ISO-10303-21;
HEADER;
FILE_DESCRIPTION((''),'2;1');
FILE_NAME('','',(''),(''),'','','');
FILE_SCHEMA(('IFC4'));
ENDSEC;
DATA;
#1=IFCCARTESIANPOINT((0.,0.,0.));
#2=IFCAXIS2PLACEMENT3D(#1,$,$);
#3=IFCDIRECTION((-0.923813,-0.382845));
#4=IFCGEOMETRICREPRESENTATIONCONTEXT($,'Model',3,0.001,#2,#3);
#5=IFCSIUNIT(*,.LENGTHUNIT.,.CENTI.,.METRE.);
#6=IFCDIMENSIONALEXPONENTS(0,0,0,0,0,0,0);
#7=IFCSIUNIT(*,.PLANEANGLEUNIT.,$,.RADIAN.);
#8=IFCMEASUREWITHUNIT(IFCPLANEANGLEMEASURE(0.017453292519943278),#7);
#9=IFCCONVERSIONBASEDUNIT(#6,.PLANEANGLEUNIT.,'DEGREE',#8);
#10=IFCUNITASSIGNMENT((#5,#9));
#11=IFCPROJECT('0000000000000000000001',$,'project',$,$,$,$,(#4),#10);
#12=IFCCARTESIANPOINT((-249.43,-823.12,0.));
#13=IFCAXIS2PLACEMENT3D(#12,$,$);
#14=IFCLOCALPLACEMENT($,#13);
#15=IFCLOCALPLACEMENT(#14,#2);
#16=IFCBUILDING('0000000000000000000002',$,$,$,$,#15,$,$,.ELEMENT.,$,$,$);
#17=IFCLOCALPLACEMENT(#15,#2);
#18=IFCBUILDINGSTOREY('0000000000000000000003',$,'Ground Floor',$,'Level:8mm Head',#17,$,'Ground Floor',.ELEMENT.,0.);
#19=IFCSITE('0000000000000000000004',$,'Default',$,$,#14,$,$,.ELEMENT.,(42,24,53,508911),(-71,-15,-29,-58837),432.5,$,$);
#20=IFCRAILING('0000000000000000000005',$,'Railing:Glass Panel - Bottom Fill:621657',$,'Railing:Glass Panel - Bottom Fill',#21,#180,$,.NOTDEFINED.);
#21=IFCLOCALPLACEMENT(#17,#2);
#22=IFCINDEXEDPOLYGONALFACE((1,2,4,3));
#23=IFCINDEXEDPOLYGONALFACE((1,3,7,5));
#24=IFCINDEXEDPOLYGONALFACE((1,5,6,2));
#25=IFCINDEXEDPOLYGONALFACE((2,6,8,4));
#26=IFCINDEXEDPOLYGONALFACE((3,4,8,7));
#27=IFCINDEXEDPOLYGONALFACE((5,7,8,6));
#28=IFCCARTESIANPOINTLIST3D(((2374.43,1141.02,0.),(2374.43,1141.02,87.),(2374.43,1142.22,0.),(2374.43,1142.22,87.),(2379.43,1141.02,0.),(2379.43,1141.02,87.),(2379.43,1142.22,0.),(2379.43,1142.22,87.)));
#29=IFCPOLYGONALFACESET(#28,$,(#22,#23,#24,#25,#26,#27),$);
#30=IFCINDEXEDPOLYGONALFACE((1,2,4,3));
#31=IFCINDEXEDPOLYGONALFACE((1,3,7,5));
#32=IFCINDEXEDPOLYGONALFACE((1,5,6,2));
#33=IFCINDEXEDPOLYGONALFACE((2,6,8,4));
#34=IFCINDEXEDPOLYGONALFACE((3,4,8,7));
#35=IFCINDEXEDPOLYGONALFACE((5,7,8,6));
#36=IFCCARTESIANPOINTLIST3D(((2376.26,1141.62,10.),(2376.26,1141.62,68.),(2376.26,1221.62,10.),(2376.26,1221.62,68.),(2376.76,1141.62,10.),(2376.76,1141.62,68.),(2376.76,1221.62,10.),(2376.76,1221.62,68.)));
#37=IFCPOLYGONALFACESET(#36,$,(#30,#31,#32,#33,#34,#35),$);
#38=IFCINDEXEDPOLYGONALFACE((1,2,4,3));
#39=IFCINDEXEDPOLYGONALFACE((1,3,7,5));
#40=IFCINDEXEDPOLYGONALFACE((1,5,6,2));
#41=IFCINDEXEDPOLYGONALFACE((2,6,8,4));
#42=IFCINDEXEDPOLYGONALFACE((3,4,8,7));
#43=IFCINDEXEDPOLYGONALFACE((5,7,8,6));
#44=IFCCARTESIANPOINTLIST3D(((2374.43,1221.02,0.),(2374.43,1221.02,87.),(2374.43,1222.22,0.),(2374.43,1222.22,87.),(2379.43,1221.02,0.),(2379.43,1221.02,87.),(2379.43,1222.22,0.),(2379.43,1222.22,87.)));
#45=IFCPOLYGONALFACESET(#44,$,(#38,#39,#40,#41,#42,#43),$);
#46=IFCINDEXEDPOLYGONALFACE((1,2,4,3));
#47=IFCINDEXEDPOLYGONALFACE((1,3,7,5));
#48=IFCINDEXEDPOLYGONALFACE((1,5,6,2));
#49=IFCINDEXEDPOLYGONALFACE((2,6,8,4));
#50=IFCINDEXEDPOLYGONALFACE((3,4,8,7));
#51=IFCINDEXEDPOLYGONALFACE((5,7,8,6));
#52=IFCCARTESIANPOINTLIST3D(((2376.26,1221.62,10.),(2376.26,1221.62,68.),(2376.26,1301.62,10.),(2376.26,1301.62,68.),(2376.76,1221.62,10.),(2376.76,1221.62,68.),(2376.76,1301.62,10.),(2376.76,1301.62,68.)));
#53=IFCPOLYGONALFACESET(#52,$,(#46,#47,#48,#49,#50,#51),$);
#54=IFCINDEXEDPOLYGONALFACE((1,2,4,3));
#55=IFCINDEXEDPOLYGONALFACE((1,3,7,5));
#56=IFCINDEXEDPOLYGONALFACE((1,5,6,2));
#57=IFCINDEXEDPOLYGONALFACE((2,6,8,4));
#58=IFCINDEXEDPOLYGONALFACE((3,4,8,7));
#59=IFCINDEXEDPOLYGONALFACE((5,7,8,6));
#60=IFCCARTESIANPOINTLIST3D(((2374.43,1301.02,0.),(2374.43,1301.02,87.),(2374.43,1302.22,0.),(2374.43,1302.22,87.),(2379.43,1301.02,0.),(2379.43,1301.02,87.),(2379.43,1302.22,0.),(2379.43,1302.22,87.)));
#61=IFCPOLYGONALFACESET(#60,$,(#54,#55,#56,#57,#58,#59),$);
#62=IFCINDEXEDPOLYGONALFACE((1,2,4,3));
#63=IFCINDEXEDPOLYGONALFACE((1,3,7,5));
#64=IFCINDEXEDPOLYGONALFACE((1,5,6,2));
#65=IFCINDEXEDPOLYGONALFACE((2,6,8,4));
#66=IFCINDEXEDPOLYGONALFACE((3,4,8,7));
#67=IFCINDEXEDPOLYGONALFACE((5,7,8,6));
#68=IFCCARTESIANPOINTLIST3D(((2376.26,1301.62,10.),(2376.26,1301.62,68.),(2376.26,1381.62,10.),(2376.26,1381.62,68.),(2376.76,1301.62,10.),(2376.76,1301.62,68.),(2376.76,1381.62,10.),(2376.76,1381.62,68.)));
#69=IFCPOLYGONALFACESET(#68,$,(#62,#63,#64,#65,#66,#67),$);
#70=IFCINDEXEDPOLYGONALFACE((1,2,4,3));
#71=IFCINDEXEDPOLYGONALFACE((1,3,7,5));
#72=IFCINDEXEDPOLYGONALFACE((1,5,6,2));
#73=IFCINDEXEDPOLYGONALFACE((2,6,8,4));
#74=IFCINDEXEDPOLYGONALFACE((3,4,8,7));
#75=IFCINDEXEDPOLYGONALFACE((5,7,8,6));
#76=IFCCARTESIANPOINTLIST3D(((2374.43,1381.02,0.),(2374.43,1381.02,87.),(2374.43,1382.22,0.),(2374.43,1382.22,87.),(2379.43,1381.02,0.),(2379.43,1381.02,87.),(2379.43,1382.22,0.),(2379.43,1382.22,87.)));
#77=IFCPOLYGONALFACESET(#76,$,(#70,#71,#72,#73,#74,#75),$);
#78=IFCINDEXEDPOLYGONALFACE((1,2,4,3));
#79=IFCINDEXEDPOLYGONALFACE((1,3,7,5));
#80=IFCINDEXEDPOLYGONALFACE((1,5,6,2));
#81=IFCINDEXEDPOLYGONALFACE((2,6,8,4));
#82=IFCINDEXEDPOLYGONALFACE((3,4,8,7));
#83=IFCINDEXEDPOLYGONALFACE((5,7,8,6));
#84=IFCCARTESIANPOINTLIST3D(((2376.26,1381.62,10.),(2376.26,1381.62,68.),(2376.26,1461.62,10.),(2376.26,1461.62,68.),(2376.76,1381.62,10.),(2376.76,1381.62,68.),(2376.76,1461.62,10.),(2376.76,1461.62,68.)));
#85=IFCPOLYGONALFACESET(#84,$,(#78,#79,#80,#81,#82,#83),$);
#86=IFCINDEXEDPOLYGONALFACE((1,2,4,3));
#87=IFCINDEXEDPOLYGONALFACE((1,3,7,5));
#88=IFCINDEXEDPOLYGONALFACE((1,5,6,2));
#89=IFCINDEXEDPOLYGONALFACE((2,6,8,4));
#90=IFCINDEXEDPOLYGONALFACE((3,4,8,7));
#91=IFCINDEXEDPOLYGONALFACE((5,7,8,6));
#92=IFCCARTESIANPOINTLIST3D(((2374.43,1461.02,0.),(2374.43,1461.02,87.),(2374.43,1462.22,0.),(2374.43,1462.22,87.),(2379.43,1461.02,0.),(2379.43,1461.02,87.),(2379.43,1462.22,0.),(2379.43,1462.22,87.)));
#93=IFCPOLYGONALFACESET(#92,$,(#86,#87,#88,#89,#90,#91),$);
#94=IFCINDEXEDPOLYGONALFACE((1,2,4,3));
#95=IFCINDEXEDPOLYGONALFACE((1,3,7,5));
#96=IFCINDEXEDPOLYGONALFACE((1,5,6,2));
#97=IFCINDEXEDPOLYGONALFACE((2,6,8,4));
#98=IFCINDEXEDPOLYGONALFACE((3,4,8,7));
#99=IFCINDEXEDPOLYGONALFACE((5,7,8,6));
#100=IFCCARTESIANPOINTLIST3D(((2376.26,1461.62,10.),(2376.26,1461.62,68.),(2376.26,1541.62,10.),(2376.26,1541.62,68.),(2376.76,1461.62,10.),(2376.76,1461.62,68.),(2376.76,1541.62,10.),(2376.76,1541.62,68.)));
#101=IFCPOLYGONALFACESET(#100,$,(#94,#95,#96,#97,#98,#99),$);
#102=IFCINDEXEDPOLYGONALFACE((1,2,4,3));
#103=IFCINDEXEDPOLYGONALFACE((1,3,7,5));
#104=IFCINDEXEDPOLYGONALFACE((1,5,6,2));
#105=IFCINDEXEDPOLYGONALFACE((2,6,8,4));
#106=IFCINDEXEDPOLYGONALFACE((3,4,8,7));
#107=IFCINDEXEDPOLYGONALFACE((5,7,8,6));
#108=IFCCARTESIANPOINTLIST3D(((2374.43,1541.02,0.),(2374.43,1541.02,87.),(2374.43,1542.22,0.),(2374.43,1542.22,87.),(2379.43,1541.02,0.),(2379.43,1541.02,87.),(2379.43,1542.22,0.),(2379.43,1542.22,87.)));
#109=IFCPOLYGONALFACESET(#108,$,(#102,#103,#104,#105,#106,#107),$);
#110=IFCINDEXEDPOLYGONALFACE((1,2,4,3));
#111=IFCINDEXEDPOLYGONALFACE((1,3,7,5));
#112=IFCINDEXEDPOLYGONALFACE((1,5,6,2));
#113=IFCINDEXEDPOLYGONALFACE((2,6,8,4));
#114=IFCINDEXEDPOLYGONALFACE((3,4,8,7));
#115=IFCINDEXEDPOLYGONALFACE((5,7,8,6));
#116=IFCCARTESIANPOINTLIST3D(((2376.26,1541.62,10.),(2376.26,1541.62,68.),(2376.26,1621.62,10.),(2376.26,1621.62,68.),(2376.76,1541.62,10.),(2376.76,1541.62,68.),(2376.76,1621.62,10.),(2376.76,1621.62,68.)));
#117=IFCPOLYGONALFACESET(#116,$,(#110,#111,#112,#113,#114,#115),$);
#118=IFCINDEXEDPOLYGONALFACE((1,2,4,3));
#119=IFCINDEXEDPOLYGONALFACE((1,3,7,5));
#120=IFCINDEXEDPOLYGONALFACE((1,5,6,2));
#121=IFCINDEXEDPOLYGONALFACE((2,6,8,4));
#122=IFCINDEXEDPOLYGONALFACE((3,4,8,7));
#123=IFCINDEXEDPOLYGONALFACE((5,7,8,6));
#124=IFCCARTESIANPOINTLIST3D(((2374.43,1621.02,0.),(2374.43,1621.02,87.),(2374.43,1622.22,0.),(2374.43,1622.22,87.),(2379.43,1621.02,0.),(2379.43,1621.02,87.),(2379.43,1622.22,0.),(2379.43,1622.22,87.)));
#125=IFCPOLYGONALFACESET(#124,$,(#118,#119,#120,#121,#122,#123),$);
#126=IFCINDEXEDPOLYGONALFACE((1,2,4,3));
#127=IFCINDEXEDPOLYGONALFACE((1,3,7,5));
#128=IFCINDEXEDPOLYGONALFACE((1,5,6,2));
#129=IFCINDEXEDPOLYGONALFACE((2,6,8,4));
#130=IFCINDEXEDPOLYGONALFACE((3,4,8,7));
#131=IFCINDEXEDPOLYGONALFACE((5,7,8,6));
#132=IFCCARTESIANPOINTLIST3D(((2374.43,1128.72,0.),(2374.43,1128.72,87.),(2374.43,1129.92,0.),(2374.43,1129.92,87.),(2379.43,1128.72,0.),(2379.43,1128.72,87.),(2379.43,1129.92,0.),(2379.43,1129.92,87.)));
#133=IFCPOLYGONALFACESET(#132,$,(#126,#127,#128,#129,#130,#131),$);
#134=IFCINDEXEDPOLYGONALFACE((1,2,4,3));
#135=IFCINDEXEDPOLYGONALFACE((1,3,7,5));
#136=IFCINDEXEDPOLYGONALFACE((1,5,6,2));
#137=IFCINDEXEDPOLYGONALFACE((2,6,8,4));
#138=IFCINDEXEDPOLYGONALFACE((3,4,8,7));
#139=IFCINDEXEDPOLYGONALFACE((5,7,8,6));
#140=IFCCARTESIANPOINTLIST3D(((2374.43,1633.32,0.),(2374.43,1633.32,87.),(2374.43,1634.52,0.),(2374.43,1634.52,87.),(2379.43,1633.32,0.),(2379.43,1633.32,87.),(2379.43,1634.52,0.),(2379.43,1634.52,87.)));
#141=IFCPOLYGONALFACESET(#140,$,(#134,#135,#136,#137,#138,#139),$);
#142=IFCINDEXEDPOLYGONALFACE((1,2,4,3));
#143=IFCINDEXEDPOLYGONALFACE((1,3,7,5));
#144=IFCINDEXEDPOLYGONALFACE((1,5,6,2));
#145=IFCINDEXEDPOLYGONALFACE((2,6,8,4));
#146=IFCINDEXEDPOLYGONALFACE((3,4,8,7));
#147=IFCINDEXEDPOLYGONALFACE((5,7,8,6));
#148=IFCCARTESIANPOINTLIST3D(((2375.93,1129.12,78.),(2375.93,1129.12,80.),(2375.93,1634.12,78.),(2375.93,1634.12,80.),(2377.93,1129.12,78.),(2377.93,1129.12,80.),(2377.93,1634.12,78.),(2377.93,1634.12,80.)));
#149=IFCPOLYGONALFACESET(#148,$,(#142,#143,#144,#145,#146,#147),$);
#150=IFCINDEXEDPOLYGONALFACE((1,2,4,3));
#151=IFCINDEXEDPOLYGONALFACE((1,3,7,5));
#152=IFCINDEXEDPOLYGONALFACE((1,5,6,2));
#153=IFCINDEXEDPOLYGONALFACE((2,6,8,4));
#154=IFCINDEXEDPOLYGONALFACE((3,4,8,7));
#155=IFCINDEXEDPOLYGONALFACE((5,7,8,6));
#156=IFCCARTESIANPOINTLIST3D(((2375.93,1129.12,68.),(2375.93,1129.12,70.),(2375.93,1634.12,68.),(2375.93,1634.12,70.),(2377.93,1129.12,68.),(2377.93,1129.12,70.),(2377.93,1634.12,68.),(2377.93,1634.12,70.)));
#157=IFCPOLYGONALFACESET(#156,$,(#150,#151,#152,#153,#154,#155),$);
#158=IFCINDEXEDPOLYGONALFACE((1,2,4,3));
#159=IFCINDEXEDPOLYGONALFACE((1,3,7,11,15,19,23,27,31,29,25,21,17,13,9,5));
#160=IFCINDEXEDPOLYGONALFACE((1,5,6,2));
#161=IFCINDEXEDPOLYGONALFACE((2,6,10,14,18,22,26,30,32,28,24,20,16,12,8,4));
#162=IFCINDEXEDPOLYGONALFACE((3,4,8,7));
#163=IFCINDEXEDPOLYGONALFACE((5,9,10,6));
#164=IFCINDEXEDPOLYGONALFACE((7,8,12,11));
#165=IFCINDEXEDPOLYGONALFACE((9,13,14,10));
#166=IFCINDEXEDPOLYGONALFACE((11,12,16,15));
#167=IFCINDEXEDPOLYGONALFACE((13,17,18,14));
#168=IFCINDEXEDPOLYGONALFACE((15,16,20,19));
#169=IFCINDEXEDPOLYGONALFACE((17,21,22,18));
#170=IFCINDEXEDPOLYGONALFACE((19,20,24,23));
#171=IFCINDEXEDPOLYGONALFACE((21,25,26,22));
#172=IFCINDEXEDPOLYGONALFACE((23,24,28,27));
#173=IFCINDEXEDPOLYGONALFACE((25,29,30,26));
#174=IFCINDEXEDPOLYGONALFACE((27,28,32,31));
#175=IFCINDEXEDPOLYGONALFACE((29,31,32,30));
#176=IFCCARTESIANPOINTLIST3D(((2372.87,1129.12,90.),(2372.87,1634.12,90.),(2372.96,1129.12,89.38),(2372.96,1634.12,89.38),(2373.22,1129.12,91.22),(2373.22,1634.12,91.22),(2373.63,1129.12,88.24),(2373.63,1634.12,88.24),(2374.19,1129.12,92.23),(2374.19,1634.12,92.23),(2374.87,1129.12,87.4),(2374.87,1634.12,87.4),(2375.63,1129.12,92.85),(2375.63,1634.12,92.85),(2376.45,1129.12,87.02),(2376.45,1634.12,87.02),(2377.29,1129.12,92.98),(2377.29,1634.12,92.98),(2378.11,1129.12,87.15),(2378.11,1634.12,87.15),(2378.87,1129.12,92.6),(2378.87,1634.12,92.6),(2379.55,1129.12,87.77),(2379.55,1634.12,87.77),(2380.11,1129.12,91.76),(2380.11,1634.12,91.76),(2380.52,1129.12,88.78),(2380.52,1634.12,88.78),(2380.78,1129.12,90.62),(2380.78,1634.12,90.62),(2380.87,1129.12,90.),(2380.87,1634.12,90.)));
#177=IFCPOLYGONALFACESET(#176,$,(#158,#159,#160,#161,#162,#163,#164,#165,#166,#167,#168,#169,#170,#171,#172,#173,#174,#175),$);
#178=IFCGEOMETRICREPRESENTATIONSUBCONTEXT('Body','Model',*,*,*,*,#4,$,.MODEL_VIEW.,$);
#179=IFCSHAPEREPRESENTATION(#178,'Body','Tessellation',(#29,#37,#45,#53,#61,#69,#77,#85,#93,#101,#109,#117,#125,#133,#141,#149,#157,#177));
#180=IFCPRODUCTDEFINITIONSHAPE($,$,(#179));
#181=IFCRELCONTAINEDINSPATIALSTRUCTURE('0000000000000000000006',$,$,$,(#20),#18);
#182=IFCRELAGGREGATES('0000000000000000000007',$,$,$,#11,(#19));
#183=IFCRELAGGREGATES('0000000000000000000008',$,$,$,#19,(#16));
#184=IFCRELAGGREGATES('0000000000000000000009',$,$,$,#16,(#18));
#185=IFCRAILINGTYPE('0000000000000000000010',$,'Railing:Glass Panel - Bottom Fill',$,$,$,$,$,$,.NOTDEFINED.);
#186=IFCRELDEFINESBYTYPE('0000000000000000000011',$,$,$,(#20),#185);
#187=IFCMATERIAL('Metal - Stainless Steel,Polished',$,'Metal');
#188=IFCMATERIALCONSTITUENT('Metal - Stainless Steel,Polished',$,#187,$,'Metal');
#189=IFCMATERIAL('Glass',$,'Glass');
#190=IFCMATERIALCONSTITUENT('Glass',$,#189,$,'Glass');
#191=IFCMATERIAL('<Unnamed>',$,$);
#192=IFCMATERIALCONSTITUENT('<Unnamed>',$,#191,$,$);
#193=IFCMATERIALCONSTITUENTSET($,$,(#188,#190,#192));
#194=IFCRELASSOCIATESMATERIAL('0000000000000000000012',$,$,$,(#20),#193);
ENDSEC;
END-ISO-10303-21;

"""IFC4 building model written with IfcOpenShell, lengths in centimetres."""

from ifc_helpers import new_model, entity, si_unit, converted_unit, direction, frame, origin, place, context, subcontext, project, spatial, indexed_curve, outline, extrude, material, constituent, constituent_set, type_object, element, save


model = new_model("IFC4")

# Units and contexts
model_context = context("Model", 3, precision=0.001, world=origin(), true_north=direction((-0.923813, -0.382845)))
body_context = subcontext(model_context, "Body", "Model", "MODEL_VIEW")
ifc_project = project(units=[si_unit("LENGTHUNIT", "METRE", prefix="CENTI"), converted_unit("PLANEANGLEUNIT", "DEGREE", entity("IfcPlaneAngleMeasure", 0.017453292519943278), si_unit("PLANEANGLEUNIT", "RADIAN"), dimensions=[0, 0, 0, 0, 0, 0, 0])], contexts=[model_context])

# Site, building, storey
site_placement = place(None, frame((-249.43, -823.12, 0.0)))
site = spatial("IfcSite", under=ifc_project, at=site_placement, Name="Default", CompositionType="ELEMENT", RefLatitude=(42, 24, 53, 508911), RefLongitude=(-71, -15, -29, -58837), RefElevation=432.5)
building_placement = place(site_placement, origin())
building = spatial("IfcBuilding", under=site, at=building_placement, CompositionType="ELEMENT")
storey_placement = place(building_placement, origin())
storey = spatial("IfcBuildingStorey", under=building, at=storey_placement, Name="Ground Floor", ObjectType="Level:8mm Head", LongName="Ground Floor", CompositionType="ELEMENT", Elevation=0.0)

# Shared definitions
ifc_material_1 = material(Name="Glass", Category="Glass")

# Railing
ifc_material_2 = material(Name="Metal - Stainless Steel,Polished", Category="Metal")
ifc_material_3 = material(Name="<Unnamed>")
railing_type = type_object("IfcRailingType", Name="Railing:Glass Panel - Bottom Fill", PredefinedType="NOTDEFINED")
ifc_constituent_1 = constituent(ifc_material_2, Name="Metal - Stainless Steel,Polished", Category="Metal")
ifc_constituent_2 = constituent(ifc_material_1, Name="Glass", Category="Glass")
ifc_constituent_3 = constituent(ifc_material_3, Name="<Unnamed>")
ifc_constituent_set_1 = constituent_set(constituents=[ifc_constituent_1, ifc_constituent_2, ifc_constituent_3])
railing_1_placement = place(storey_placement, origin())
element("IfcRailing", 1, at=railing_1_placement, inside=storey, type_object=railing_type, material=ifc_constituent_set_1, Name="Railing:Glass Panel - Bottom Fill:621657", ObjectType="Railing:Glass Panel - Bottom Fill", PredefinedType="NOTDEFINED", context=body_context, shape_type="SweptSolid", body=[
    extrude(outline(indexed_curve([(-2.5, -0.6), (2.5, -0.6), (2.5, 0.6), (-2.5, 0.6), (-2.5, -0.6)], self_intersect=False)), frame((2376.93, 1141.62, 0.0), z_axis=(0.0, 0.0, 1.0), x_axis=(-1.0, 0.0, 0.0)), (0.0, 0.0, 1.0), 87.0),
    extrude(outline(indexed_curve([(-0.25, -40.0), (0.25, -40.0), (0.25, 40.0), (-0.25, 40.0), (-0.25, -40.0)], self_intersect=False)), frame((2376.51, 1181.62, 10.0), z_axis=(0.0, 0.0, 1.0), x_axis=(-1.0, 0.0, 0.0)), (0.0, 0.0, 1.0), 58.0),
    extrude(outline(indexed_curve([(-2.5, -0.6), (2.5, -0.6), (2.5, 0.6), (-2.5, 0.6), (-2.5, -0.6)], self_intersect=False)), frame((2376.93, 1221.62, 0.0), z_axis=(0.0, 0.0, 1.0), x_axis=(-1.0, 0.0, 0.0)), (0.0, 0.0, 1.0), 87.0),
    extrude(outline(indexed_curve([(-0.25, -40.0), (0.25, -40.0), (0.25, 40.0), (-0.25, 40.0), (-0.25, -40.0)], self_intersect=False)), frame((2376.51, 1261.62, 10.0), z_axis=(0.0, 0.0, 1.0), x_axis=(-1.0, 0.0, 0.0)), (0.0, 0.0, 1.0), 58.0),
    extrude(outline(indexed_curve([(-2.5, -0.6), (2.5, -0.6), (2.5, 0.6), (-2.5, 0.6), (-2.5, -0.6)], self_intersect=False)), frame((2376.93, 1301.62, 0.0), z_axis=(0.0, 0.0, 1.0), x_axis=(-1.0, 0.0, 0.0)), (0.0, 0.0, 1.0), 87.0),
    extrude(outline(indexed_curve([(-0.25, -40.0), (0.25, -40.0), (0.25, 40.0), (-0.25, 40.0), (-0.25, -40.0)], self_intersect=False)), frame((2376.51, 1341.62, 10.0), z_axis=(0.0, 0.0, 1.0), x_axis=(-1.0, 0.0, 0.0)), (0.0, 0.0, 1.0), 58.0),
    extrude(outline(indexed_curve([(-2.5, -0.6), (2.5, -0.6), (2.5, 0.6), (-2.5, 0.6), (-2.5, -0.6)], self_intersect=False)), frame((2376.93, 1381.62, 0.0), z_axis=(0.0, 0.0, 1.0), x_axis=(-1.0, 0.0, 0.0)), (0.0, 0.0, 1.0), 87.0),
    extrude(outline(indexed_curve([(-0.25, -40.0), (0.25, -40.0), (0.25, 40.0), (-0.25, 40.0), (-0.25, -40.0)], self_intersect=False)), frame((2376.51, 1421.62, 10.0), z_axis=(0.0, 0.0, 1.0), x_axis=(-1.0, 0.0, 0.0)), (0.0, 0.0, 1.0), 58.0),
    extrude(outline(indexed_curve([(-2.5, -0.6), (2.5, -0.6), (2.5, 0.6), (-2.5, 0.6), (-2.5, -0.6)], self_intersect=False)), frame((2376.93, 1461.62, 0.0), z_axis=(0.0, 0.0, 1.0), x_axis=(-1.0, 0.0, 0.0)), (0.0, 0.0, 1.0), 87.0),
    extrude(outline(indexed_curve([(-0.25, -40.0), (0.25, -40.0), (0.25, 40.0), (-0.25, 40.0), (-0.25, -40.0)], self_intersect=False)), frame((2376.51, 1501.62, 10.0), z_axis=(0.0, 0.0, 1.0), x_axis=(-1.0, 0.0, 0.0)), (0.0, 0.0, 1.0), 58.0),
    extrude(outline(indexed_curve([(-2.5, -0.6), (2.5, -0.6), (2.5, 0.6), (-2.5, 0.6), (-2.5, -0.6)], self_intersect=False)), frame((2376.93, 1541.62, 0.0), z_axis=(0.0, 0.0, 1.0), x_axis=(-1.0, 0.0, 0.0)), (0.0, 0.0, 1.0), 87.0),
    extrude(outline(indexed_curve([(-0.25, -40.0), (0.25, -40.0), (0.25, 40.0), (-0.25, 40.0), (-0.25, -40.0)], self_intersect=False)), frame((2376.51, 1581.62, 10.0), z_axis=(0.0, 0.0, 1.0), x_axis=(-1.0, 0.0, 0.0)), (0.0, 0.0, 1.0), 58.0),
    extrude(outline(indexed_curve([(-2.5, -0.6), (2.5, -0.6), (2.5, 0.6), (-2.5, 0.6), (-2.5, -0.6)], self_intersect=False)), frame((2376.93, 1621.62, 0.0), z_axis=(0.0, 0.0, 1.0), x_axis=(-1.0, 0.0, 0.0)), (0.0, 0.0, 1.0), 87.0),
    extrude(outline(indexed_curve([(-2.5, -0.6), (2.5, -0.6), (2.5, 0.6), (-2.5, 0.6), (-2.5, -0.6)], self_intersect=False)), frame((2376.93, 1129.32, 0.0), z_axis=(0.0, 0.0, 1.0), x_axis=(-1.0, 0.0, 0.0)), (0.0, 0.0, 1.0), 87.0),
    extrude(outline(indexed_curve([(-2.5, -0.6), (2.5, -0.6), (2.5, 0.6), (-2.5, 0.6), (-2.5, -0.6)], self_intersect=False)), frame((2376.93, 1633.92, 0.0), z_axis=(0.0, 0.0, 1.0), x_axis=(-1.0, 0.0, 0.0)), (0.0, 0.0, 1.0), 87.0),
    extrude(outline(indexed_curve([(-252.5, -1.0), (252.5, -1.0), (252.5, 1.0), (-252.5, 1.0), (-252.5, -1.0)], self_intersect=False)), frame((2376.93, 1381.62, 78.0), z_axis=(0.0, 0.0, 1.0), x_axis=(0.0, -1.0, 0.0)), (0.0, 0.0, 1.0), 2.0),
    extrude(outline(indexed_curve([(-252.5, -1.0), (252.5, -1.0), (252.5, 1.0), (-252.5, 1.0), (-252.5, -1.0)], self_intersect=False)), frame((2376.93, 1381.62, 68.0), z_axis=(0.0, 0.0, 1.0), x_axis=(0.0, -1.0, 0.0)), (0.0, 0.0, 1.0), 2.0),
    extrude(outline(indexed_curve([(-1.09, -3.85), (0.18, -3.85), (1.42, -3.18), (2.41, -1.97), (2.98, -0.41), (3.04, 1.22), (2.58, 2.63), (1.67, 3.59), (1.09, 3.85), (-0.18, 3.85), (-1.42, 3.18), (-2.41, 1.97), (-2.98, 0.41), (-3.04, -1.22), (-2.58, -2.63), (-1.67, -3.59), (-1.09, -3.85)], self_intersect=False)), frame((2376.87, 1129.12, 90.0), z_axis=(0.0, 1.0, 0.0), x_axis=(-0.27267, 0.0, -0.962108)), (0.0, 0.0, 1.0), 505.0),
])

save(model, "model.ifc")
